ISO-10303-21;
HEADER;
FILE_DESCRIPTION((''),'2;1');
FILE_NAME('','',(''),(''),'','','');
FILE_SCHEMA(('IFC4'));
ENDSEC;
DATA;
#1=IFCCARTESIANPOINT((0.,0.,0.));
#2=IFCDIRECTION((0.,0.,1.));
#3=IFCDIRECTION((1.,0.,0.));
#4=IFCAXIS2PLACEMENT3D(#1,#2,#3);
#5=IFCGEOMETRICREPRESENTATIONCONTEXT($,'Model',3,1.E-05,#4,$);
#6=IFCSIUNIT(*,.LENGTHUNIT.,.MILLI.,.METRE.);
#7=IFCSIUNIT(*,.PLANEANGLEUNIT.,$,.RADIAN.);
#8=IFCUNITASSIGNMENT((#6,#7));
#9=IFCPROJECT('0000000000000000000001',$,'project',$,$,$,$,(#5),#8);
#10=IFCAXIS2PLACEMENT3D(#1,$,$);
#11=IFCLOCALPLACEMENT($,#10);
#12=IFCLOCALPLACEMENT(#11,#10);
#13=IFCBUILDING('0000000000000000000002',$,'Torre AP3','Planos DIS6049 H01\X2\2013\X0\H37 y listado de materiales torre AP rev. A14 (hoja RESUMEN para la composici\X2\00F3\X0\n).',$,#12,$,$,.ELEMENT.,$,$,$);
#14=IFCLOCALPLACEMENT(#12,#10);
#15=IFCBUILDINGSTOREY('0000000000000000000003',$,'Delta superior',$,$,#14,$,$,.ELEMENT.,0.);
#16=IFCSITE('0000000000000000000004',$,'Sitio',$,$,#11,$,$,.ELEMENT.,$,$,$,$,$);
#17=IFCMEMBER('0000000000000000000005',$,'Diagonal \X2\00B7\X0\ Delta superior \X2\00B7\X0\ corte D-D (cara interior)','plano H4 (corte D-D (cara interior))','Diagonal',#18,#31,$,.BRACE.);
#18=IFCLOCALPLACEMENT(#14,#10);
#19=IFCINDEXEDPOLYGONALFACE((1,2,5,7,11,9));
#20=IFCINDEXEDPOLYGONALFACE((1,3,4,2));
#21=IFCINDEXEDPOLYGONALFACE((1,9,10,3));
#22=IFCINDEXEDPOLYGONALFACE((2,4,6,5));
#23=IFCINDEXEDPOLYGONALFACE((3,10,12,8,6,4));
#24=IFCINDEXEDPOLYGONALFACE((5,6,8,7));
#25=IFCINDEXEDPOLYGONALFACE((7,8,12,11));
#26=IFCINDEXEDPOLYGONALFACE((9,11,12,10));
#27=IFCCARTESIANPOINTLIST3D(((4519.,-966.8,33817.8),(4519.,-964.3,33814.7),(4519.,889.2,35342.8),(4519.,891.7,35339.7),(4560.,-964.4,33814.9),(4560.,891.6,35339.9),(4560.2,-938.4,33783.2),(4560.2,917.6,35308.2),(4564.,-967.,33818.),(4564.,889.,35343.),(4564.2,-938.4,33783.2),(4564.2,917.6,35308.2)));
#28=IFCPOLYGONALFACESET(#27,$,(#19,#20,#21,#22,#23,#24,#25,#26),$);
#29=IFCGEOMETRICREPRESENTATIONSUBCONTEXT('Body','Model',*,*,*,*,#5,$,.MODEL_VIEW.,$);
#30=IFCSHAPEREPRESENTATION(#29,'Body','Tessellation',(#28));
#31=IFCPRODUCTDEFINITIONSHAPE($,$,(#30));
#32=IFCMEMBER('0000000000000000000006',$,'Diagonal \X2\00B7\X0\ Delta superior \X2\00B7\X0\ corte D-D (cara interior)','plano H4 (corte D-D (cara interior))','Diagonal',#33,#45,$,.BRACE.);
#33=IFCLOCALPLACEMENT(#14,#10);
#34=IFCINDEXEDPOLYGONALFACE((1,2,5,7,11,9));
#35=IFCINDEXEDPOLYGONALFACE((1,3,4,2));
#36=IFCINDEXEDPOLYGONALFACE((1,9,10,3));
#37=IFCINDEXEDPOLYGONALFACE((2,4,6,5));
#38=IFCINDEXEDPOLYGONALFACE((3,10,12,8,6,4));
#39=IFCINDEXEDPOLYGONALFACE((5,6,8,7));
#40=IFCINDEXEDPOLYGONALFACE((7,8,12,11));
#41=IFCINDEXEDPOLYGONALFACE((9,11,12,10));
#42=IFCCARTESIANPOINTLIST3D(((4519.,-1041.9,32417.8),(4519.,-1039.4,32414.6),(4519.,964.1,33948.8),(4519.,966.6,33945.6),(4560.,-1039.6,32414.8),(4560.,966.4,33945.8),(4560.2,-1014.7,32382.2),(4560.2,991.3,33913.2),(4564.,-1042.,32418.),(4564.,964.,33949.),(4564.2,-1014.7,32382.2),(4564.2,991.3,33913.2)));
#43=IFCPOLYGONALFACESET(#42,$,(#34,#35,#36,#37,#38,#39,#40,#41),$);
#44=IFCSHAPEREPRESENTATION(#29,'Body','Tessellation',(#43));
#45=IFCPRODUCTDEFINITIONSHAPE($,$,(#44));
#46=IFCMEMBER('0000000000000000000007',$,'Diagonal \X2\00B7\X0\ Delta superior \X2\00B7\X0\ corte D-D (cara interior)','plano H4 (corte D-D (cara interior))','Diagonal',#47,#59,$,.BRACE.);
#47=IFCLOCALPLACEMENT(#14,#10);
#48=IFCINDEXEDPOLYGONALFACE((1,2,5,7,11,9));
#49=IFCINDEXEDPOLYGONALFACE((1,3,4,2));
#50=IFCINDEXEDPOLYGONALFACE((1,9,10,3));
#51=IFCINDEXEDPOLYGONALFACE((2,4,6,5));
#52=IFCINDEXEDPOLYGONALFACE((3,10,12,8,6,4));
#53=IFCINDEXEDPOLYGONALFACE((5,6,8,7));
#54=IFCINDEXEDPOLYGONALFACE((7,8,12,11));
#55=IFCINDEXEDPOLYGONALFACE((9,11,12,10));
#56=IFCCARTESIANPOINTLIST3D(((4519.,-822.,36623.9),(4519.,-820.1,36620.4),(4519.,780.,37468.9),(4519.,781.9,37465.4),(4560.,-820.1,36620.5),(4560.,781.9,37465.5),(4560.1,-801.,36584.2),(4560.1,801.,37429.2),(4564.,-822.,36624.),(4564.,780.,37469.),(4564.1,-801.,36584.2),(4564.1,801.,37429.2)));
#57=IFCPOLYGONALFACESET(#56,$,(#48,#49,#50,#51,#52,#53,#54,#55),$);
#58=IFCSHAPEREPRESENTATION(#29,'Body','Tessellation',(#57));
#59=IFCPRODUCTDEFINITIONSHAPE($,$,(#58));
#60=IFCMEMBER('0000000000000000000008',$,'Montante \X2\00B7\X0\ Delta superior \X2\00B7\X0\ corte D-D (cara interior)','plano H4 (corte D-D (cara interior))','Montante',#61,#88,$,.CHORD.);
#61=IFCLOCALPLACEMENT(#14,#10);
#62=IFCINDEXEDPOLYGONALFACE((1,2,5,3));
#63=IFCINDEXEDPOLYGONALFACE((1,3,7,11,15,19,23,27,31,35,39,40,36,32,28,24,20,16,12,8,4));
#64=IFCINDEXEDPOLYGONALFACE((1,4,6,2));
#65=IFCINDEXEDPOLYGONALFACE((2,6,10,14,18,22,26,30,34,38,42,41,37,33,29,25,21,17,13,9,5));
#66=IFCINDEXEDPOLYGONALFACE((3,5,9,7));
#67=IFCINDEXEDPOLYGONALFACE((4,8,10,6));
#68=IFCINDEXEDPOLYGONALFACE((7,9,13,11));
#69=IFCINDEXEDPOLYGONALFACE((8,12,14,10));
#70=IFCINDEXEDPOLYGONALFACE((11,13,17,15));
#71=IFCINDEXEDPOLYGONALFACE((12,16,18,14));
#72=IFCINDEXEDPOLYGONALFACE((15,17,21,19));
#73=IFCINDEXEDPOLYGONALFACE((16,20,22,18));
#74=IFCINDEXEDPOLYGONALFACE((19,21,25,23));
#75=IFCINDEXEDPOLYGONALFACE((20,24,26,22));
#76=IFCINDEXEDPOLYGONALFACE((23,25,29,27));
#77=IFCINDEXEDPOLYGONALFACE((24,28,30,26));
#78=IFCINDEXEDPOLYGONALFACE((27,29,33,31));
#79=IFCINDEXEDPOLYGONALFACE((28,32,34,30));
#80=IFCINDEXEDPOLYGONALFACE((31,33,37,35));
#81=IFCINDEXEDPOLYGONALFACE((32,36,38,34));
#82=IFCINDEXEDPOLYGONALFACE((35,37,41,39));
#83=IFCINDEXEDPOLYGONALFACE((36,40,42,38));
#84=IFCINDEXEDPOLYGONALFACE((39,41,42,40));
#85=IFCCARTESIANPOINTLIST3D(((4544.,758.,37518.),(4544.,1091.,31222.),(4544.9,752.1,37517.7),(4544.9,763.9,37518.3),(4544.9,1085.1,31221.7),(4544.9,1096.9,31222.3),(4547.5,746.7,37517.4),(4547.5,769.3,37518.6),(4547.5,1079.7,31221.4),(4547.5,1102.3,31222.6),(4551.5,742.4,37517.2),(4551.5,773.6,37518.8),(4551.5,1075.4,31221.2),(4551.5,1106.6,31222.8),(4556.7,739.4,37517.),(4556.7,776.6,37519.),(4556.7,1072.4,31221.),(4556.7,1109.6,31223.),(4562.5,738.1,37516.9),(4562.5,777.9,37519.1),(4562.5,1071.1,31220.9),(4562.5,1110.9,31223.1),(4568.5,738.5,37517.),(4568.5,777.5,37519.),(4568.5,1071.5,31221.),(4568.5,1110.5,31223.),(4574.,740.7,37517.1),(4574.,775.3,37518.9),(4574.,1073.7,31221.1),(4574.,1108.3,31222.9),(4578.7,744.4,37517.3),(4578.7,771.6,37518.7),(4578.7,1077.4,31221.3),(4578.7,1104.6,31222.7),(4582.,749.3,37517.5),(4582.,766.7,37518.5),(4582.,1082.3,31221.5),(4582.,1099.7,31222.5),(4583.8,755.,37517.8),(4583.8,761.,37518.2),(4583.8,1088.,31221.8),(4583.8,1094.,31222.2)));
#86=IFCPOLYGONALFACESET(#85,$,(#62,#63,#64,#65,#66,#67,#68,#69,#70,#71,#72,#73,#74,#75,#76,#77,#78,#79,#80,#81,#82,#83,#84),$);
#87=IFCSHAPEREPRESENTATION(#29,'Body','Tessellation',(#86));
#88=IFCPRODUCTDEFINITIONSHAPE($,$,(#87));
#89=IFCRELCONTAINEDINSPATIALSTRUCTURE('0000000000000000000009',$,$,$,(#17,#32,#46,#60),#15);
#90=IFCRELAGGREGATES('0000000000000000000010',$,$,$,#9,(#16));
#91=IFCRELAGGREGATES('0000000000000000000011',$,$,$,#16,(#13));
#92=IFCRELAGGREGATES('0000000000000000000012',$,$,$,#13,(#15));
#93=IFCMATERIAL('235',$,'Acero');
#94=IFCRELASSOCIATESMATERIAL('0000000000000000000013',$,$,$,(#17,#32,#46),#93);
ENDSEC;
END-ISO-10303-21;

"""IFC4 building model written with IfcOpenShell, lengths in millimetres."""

from ifc_helpers import new_model, si_unit, frame, frame_2d, origin, origin_with_axes, place, context, subcontext, project, spatial, circle, l_section, extrude, material, element, save


model = new_model("IFC4")

# Units and contexts
model_context = context("Model", 3, precision=1e-05, world=origin_with_axes())
body_context = subcontext(model_context, "Body", "Model", "MODEL_VIEW")
ifc_project = project(units=[si_unit("LENGTHUNIT", "METRE", prefix="MILLI"), si_unit("PLANEANGLEUNIT", "RADIAN")], contexts=[model_context])

# Site, building, storey
site_placement = place(None, origin())
site = spatial("IfcSite", under=ifc_project, at=site_placement, Name="Sitio", CompositionType="ELEMENT")
building_placement = place(site_placement, origin())
building = spatial("IfcBuilding", under=site, at=building_placement, Name="Torre AP3", Description="Planos DIS6049 H01–H37 y listado de materiales torre AP rev. A14 (hoja RESUMEN para la composición).", CompositionType="ELEMENT")
storey_placement = place(building_placement, origin())
storey = spatial("IfcBuildingStorey", under=building, at=storey_placement, Name="Delta superior", CompositionType="ELEMENT", Elevation=0.0)

# Members
ifc_material_1 = material(Name="235", Category="Acero")
member_1_placement = place(storey_placement, frame((4564.0, 889.0, 35343.0), z_axis=(0.0, -0.772639, -0.634846), x_axis=(-0.999985, 0.003444, -0.004191)))
element("IfcMember", 1, at=member_1_placement, inside=storey, material=ifc_material_1, Name="Diagonal · Delta superior · corte D-D (cara interior)", Description="plano H4 (corte D-D (cara interior))", ObjectType="Diagonal", PredefinedType="BRACE", context=body_context, shape_type="SweptSolid", body=[
    extrude(l_section(Depth=45.0, Width=45.0, Thickness=4.0, at=frame_2d((22.5, 22.5))), None, (0.0, 0.0, 1.0), 2402.2),
])
member_2_placement = place(storey_placement, frame((4564.0, 964.0, 33949.0), z_axis=(0.0, -0.794931, -0.6067), x_axis=(-0.999987, 0.003145, -0.004121)))
element("IfcMember", 2, at=member_2_placement, inside=storey, material=ifc_material_1, Name="Diagonal · Delta superior · corte D-D (cara interior)", Description="plano H4 (corte D-D (cara interior))", ObjectType="Diagonal", PredefinedType="BRACE", context=body_context, shape_type="SweptSolid", body=[
    extrude(l_section(Depth=45.0, Width=45.0, Thickness=4.0, at=frame_2d((22.5, 22.5))), None, (0.0, 0.0, 1.0), 2523.5),
])
member_3_placement = place(storey_placement, frame((4564.0, 780.0, 37469.0), z_axis=(0.0, -0.884499, -0.466543), x_axis=(-0.999998, 0.001002, -0.001899)))
element("IfcMember", 3, at=member_3_placement, inside=storey, material=ifc_material_1, Name="Diagonal · Delta superior · corte D-D (cara interior)", Description="plano H4 (corte D-D (cara interior))", ObjectType="Diagonal", PredefinedType="BRACE", context=body_context, shape_type="SweptSolid", body=[
    extrude(l_section(Depth=45.0, Width=45.0, Thickness=4.0, at=frame_2d((22.5, 22.5))), None, (0.0, 0.0, 1.0), 1811.2),
])
member_4_placement = place(storey_placement, frame((4564.0, 1091.0, 31222.0), z_axis=(0.0, -0.052817, 0.998604), x_axis=(-1.0, 0.0, 0.0)))
element("IfcMember", 4, at=member_4_placement, inside=storey, Name="Montante · Delta superior · corte D-D (cara interior)", Description="plano H4 (corte D-D (cara interior))", ObjectType="Montante", PredefinedType="CHORD", context=body_context, shape_type="SweptSolid", body=[
    extrude(circle(Radius=20.0), None, (0.0, 0.0, 1.0), 6304.8),
])

save(model, "model.ifc")
